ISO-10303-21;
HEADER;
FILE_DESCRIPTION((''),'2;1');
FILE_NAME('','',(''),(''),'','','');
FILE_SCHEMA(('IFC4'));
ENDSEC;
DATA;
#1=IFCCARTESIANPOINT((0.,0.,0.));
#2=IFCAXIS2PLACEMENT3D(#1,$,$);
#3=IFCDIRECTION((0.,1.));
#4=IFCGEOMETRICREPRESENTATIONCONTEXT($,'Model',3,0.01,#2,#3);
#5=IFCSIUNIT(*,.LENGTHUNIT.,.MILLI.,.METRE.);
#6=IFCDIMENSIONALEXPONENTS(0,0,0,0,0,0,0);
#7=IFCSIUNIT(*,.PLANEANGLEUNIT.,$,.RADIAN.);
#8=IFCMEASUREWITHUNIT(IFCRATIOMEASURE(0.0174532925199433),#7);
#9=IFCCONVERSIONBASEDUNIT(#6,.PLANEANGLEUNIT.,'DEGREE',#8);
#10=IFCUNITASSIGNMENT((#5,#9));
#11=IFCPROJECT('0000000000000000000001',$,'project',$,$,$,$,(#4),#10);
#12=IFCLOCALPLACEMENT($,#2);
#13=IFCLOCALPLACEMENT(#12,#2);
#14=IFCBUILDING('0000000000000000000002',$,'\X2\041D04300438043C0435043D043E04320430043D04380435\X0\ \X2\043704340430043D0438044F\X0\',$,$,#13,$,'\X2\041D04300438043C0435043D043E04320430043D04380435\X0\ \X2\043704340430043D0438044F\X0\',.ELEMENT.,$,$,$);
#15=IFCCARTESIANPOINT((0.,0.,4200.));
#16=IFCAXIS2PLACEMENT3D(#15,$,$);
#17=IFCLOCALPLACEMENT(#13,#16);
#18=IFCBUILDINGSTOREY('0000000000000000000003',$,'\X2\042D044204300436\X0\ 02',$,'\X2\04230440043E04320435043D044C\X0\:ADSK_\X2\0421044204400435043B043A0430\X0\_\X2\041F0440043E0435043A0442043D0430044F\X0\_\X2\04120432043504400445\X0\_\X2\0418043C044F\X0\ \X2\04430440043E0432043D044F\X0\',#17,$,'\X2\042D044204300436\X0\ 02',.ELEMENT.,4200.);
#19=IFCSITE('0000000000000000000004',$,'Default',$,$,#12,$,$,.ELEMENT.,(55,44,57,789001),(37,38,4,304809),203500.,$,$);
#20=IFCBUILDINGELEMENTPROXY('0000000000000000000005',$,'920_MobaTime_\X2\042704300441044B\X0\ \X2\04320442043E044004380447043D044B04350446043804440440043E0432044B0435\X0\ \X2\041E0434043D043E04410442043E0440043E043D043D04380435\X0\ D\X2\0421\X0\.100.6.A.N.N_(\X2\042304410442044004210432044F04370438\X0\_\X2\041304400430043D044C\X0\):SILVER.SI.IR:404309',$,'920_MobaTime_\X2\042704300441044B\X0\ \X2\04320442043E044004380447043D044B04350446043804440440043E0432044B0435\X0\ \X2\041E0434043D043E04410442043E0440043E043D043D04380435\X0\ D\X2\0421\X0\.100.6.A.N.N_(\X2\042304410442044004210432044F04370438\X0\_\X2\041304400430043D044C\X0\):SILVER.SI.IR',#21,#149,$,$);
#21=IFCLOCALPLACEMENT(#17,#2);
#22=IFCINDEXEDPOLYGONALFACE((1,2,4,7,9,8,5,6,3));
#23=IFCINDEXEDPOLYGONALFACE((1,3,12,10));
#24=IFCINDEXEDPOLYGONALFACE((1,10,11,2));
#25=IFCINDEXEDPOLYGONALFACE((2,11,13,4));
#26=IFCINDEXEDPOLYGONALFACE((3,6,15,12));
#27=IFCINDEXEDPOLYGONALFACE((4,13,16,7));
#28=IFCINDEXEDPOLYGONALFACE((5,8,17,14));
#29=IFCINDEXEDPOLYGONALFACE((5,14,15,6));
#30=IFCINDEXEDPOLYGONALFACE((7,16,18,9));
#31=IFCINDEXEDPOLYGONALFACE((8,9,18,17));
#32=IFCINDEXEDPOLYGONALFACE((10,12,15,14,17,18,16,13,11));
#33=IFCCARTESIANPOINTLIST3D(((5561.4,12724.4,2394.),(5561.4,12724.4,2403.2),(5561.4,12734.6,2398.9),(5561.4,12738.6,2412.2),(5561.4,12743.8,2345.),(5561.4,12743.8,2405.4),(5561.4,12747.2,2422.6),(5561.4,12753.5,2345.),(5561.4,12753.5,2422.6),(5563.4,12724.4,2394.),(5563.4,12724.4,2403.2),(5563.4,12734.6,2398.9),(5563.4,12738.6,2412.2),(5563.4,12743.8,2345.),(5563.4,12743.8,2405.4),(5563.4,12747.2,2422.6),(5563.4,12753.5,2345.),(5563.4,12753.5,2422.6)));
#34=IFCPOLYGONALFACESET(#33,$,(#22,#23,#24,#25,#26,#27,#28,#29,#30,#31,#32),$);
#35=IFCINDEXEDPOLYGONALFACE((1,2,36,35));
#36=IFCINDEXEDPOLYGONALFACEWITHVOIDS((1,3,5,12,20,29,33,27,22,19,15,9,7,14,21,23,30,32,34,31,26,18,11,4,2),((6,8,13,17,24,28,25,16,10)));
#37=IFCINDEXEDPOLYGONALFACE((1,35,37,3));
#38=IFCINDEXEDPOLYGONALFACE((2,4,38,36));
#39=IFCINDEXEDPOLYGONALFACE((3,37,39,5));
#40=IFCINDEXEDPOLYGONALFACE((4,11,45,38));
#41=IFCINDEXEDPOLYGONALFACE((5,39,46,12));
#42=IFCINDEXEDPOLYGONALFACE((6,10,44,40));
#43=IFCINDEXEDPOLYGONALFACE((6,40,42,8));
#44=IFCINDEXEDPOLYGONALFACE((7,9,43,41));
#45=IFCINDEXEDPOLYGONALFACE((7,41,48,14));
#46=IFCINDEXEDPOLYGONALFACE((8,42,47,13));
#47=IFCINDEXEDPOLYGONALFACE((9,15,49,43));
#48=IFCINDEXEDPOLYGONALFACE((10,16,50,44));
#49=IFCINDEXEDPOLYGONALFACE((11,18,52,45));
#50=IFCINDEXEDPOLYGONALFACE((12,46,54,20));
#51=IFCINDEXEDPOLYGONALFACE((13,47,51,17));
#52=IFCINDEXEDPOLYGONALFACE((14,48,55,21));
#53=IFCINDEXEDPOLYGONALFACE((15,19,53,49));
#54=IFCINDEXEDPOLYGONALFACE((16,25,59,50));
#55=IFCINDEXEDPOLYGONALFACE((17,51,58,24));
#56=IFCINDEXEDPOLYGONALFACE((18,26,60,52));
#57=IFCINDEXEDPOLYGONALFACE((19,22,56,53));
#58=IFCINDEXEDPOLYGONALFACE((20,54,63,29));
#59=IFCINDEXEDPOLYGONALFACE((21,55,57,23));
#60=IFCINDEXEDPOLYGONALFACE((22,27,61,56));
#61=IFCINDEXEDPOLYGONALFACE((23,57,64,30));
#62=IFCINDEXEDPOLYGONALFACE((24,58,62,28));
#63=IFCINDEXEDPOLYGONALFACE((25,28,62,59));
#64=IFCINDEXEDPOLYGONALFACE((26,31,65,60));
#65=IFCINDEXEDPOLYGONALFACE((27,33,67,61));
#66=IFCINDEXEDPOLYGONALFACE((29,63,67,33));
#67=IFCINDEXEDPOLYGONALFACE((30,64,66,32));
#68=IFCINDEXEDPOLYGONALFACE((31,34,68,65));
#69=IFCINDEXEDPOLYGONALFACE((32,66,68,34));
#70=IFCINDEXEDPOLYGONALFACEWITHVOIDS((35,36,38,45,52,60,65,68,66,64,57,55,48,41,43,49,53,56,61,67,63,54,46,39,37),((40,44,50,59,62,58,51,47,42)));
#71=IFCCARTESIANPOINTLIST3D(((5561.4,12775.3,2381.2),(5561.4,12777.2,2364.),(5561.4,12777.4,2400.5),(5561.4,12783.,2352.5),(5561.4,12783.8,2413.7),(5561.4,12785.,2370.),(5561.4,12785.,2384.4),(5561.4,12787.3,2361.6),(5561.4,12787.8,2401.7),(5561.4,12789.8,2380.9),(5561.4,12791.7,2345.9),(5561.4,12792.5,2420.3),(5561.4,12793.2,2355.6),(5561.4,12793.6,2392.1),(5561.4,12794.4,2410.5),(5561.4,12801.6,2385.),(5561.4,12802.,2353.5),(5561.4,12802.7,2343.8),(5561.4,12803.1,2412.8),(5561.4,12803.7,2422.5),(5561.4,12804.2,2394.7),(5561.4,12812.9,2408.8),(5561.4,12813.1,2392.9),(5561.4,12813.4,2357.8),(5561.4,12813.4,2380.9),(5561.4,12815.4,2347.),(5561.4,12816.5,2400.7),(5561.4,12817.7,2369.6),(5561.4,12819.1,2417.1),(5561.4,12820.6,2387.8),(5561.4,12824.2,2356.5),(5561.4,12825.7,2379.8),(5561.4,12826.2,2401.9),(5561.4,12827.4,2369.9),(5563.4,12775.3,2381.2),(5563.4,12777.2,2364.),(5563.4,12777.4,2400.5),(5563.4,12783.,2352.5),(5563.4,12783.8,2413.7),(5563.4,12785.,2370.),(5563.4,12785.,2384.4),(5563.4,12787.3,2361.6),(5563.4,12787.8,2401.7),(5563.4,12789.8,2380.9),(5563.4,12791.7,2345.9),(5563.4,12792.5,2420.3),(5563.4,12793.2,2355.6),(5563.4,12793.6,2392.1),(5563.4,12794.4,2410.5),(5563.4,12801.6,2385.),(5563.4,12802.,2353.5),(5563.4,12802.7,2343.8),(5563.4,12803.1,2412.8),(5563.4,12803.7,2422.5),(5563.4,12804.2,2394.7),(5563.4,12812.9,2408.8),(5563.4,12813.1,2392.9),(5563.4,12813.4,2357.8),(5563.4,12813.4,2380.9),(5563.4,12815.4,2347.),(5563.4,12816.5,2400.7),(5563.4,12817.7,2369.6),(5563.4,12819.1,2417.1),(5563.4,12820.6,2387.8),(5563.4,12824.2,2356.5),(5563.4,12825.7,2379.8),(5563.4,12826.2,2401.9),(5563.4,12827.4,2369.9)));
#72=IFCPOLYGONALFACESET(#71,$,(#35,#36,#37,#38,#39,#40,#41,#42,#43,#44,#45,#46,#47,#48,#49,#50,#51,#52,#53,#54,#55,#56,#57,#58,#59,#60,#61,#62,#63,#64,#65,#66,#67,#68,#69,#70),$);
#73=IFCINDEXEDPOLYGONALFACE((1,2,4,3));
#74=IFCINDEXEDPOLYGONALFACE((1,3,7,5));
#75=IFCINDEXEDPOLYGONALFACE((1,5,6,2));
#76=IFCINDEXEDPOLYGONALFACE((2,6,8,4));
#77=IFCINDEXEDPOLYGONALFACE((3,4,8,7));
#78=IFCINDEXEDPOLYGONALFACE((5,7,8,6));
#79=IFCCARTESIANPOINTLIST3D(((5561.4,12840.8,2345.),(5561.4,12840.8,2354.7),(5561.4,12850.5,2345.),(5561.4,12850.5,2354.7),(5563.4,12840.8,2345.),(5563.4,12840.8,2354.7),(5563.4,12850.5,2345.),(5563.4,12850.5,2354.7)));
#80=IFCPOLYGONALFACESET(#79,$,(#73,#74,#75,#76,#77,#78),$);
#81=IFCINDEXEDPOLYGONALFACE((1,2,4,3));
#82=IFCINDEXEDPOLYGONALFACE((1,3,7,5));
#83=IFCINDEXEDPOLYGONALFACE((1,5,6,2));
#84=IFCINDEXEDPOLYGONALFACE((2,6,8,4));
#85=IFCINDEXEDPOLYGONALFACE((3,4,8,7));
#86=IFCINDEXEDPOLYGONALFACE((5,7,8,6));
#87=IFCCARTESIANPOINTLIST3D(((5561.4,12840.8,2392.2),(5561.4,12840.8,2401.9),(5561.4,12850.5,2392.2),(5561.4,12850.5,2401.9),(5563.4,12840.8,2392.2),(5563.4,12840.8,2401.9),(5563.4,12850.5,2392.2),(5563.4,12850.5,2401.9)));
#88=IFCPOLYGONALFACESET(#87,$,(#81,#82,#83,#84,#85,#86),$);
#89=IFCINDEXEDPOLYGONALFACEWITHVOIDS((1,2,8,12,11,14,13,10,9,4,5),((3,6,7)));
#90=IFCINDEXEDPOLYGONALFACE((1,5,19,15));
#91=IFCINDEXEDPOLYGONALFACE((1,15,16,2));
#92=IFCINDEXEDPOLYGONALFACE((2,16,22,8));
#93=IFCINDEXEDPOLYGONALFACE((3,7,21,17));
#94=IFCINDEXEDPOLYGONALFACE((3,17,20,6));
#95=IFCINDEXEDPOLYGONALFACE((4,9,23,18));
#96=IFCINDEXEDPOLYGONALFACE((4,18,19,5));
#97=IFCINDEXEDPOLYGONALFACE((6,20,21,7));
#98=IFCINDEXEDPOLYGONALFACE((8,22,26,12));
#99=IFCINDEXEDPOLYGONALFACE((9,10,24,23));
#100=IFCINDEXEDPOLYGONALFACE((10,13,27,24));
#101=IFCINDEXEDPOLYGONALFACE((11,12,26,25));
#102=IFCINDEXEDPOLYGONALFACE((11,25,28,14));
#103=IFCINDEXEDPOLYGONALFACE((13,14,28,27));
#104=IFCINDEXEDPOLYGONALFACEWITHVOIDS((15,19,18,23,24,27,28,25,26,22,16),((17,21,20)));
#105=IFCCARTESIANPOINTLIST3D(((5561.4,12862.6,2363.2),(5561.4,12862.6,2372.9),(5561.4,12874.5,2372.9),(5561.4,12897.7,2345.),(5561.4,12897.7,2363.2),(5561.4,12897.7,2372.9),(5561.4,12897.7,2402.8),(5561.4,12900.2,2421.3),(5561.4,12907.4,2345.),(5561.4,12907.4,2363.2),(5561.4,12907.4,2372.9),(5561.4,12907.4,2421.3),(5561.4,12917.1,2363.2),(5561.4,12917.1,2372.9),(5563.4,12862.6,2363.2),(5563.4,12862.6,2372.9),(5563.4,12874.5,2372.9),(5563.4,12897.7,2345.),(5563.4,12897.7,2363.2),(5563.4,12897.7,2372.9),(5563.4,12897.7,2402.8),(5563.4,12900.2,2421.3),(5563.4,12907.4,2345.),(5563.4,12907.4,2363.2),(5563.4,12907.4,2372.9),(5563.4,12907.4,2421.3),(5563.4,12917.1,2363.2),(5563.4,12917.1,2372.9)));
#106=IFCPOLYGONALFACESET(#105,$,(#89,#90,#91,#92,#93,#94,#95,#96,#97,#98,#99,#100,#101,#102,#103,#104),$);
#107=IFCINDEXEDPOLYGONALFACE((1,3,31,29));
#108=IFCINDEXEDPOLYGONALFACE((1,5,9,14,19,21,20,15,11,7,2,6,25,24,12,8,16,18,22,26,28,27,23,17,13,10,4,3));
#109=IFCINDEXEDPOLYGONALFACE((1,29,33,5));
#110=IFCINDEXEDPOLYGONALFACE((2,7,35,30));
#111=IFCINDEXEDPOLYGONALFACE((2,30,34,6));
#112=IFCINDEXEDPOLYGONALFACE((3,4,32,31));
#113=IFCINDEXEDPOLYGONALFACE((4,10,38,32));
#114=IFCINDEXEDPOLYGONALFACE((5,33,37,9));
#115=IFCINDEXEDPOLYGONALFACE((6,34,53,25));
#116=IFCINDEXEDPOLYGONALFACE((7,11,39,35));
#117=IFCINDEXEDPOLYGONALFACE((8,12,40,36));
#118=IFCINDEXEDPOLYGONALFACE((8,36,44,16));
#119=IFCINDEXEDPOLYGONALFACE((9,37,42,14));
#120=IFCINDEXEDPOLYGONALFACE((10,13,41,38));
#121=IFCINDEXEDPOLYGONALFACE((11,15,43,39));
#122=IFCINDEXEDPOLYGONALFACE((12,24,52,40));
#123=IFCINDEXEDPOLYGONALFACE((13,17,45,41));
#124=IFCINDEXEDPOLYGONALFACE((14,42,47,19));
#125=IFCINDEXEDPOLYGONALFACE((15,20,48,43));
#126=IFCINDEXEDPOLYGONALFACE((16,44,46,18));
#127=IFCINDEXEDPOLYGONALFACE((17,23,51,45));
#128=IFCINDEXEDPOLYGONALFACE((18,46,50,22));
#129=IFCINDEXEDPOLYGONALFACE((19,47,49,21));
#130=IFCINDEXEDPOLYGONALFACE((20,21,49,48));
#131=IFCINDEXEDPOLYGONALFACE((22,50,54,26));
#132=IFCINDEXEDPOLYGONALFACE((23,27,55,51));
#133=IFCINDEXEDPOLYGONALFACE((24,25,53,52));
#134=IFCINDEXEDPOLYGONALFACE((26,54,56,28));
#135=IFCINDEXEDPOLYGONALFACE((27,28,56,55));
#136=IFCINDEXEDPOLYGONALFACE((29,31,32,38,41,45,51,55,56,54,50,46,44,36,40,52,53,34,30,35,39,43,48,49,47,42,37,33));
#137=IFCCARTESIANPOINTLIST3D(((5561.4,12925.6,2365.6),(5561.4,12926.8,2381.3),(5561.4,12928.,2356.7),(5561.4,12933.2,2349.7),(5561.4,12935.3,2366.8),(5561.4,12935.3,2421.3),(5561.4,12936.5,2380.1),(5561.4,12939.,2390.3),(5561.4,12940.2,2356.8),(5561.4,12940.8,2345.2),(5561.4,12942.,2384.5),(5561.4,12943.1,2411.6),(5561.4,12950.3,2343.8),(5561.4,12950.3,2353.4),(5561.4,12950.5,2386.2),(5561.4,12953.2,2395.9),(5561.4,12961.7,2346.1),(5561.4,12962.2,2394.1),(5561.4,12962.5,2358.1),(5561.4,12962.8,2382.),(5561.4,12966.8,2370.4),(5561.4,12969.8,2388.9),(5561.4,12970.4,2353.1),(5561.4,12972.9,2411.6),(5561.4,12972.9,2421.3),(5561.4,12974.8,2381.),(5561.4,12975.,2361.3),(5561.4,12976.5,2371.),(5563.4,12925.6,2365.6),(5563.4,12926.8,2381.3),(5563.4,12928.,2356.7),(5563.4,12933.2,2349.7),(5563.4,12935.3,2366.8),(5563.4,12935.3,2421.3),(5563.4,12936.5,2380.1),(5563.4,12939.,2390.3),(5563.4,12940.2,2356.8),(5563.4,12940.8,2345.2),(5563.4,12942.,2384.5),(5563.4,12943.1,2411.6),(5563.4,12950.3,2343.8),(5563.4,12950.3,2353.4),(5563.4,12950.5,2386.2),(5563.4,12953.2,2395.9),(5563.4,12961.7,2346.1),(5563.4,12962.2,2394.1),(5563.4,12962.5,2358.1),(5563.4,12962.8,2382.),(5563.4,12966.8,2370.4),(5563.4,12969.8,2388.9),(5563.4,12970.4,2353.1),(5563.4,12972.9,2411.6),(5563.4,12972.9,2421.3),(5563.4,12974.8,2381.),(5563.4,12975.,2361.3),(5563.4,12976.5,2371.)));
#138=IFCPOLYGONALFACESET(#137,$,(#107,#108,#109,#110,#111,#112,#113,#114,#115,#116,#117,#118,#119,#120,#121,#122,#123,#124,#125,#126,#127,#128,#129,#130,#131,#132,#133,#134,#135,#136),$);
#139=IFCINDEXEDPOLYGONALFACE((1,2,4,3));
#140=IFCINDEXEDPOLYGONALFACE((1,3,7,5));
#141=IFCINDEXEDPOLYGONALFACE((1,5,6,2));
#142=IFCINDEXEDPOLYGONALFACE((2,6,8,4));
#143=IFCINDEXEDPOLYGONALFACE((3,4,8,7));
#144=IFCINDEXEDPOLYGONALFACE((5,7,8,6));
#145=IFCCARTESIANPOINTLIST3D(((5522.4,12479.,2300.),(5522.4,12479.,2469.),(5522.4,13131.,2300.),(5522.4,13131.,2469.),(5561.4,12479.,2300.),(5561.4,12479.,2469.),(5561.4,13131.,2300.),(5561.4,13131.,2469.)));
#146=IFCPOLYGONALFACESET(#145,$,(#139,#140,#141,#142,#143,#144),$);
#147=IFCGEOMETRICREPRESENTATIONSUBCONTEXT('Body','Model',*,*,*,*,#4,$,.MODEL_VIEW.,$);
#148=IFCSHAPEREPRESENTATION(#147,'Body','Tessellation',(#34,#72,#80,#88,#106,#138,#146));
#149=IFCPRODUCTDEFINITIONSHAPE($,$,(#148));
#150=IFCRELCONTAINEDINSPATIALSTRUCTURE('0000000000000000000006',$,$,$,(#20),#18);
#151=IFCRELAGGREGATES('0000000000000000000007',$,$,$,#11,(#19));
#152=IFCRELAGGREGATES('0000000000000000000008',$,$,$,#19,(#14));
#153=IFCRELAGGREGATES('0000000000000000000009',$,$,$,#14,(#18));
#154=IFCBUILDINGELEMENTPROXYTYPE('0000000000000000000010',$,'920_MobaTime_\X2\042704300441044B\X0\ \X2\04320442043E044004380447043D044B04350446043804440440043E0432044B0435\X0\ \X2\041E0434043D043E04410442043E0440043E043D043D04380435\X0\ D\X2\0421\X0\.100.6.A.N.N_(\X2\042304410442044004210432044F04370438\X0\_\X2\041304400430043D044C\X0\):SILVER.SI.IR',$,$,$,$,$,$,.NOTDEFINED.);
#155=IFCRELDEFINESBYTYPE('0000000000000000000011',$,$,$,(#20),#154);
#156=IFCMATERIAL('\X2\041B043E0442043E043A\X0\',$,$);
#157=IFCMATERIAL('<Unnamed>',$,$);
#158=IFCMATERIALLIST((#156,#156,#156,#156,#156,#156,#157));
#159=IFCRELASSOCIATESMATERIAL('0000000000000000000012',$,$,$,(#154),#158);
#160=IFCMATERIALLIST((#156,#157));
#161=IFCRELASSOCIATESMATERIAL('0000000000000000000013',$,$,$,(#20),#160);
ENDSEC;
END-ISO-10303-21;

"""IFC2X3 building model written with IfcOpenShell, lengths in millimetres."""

from ifc_helpers import new_model, entity, si_unit, converted_unit, direction, frame, origin, origin_2d_with_axis, place, context, subcontext, project, spatial, polyline, rectangle, outline, extrude, source, transform, mapped, material, material_list, type_object, type_shapes, element, save


model = new_model("IFC2X3")

# Units and contexts
model_context = context("Model", 3, precision=0.01, world=origin(), true_north=direction((0.0, 1.0)))
body_context = subcontext(model_context, "Body", "Model", "MODEL_VIEW")
ifc_project = project(units=[si_unit("LENGTHUNIT", "METRE", prefix="MILLI"), converted_unit("PLANEANGLEUNIT", "DEGREE", entity("IfcRatioMeasure", 0.0174532925199433), si_unit("PLANEANGLEUNIT", "RADIAN"), dimensions=[0, 0, 0, 0, 0, 0, 0])], contexts=[model_context])

# Site, building, storey
site_placement = place(None, origin())
site = spatial("IfcSite", under=ifc_project, at=site_placement, Name="Default", CompositionType="ELEMENT", RefLatitude=(55, 44, 57, 789001), RefLongitude=(37, 38, 4, 304809), RefElevation=203500.0)
building_placement = place(site_placement, origin())
building = spatial("IfcBuilding", under=site, at=building_placement, Name="Наименование здания", LongName="Наименование здания", CompositionType="ELEMENT")
storey_placement = place(building_placement, frame((0.0, 0.0, 4200.0)))
storey = spatial("IfcBuildingStorey", under=building, at=storey_placement, Name="Этаж 02", ObjectType="Уровень:ADSK_Стрелка_Проектная_Вверх_Имя уровня", LongName="Этаж 02", CompositionType="ELEMENT", Elevation=4200.0)

# Building element proxy
ifc_material_1 = material(Name="Лоток")
ifc_material_2 = material(Name="<Unnamed>")
ifc_material_list_1 = material_list([ifc_material_1, ifc_material_2])
ifc_material_list_2 = material_list([ifc_material_1, ifc_material_1, ifc_material_1, ifc_material_1, ifc_material_1, ifc_material_1, ifc_material_2])
building_element_proxy_type_1 = type_object("IfcBuildingElementProxyType", Name="920_MobaTime_Часы вторичныецифровые Односторонние DС.100.6.A.N.N_(УстрСвязи_Грань):SILVER.SI.IR", PredefinedType="NOTDEFINED", material=ifc_material_list_2)
shared_shape_1 = source(origin(), body_context, "Body", "SweptSolid", [
    extrude(outline(polyline([(-49.3, -13.1), (28.2, -13.1), (28.2, -6.8), (17.9, 1.8), (8.8, 16.0), (-0.3, 16.0), (4.6, 5.8), (11.1, -3.4), (-49.3, -3.4), (-49.3, -13.1)])), frame((-64.6, 9.8, 39.0), z_axis=(0.0, 0.0, 1.0), x_axis=(0.0, 1.0, 0.0)), (0.0, 0.0, 1.0), 2.0),
    extrude(outline(polyline([(2.2, -27.6), (19.0, -27.6), (30.5, -16.1), (33.3, -4.9), (31.0, 5.8), (21.8, 17.2), (5.2, 27.3), (-11.1, 33.0), (-24.0, 32.7), (-33.6, 27.6), (-40.3, 18.6), (-42.8, 5.7), (-38.0, -6.3), (-27.2, -14.9), (-17.5, -17.7), (-8.2, -16.4), (-0.3, -11.9), (5.1, -4.5), (7.3, 6.2), (4.0, 17.2), (18.4, 7.3), (23.6, -2.4), (22.0, -11.4), (14.2, -18.4), (5.3, -18.3), (2.2, -27.6)]), holes=[polyline([(-9.0, 23.3), (-1.3, 14.3), (-2.5, 2.0), (-11.4, -7.0), (-23.4, -6.0), (-32.2, 2.9), (-31.2, 15.1), (-25.6, 22.1), (-17.5, 24.9), (-9.0, 23.3)])]), frame((-2.7, 3.6, 39.0), z_axis=(0.0, 0.0, 1.0), x_axis=(-0.427649, 0.903945, 0.0)), (0.0, 0.0, 1.0), 2.0),
    extrude(rectangle(XDim=9.7, YDim=9.7, at=origin_2d_with_axis()), frame((40.6, -34.7, 39.0)), (0.0, 0.0, 1.0), 2.0),
    extrude(rectangle(XDim=9.7, YDim=9.7, at=origin_2d_with_axis()), frame((40.6, 12.6, 39.0)), (0.0, 0.0, 1.0), 2.0),
    extrude(outline(polyline([(-0.9, -28.1), (8.8, -28.1), (8.8, -9.9), (18.5, -9.9), (18.5, -0.2), (8.8, -0.2), (8.8, 48.3), (1.5, 48.3), (-36.0, -0.2), (-36.0, -9.9), (-0.9, -9.9), (-0.9, -28.1)]), holes=[polyline([(-0.9, -0.2), (-24.1, -0.2), (-0.9, 29.7), (-0.9, -0.2)])]), frame((93.6, -11.4, 39.0)), (0.0, 0.0, 1.0), 2.0),
    extrude(outline(polyline([(3.3, -28.3), (12.5, -28.3), (20.5, -25.0), (26.8, -18.9), (30.7, -10.0), (31.4, 1.6), (26.9, 11.8), (20.1, 18.4), (11.1, 22.3), (1.0, 23.3), (-7.9, 20.4), (-14.9, 14.5), (-18.9, 6.2), (-17.1, -9.0), (-36.7, 0.5), (-29.1, 29.2), (-38.5, 31.7), (-48.1, -4.6), (-11.6, -23.1), (-8.0, -14.0), (-10.8, -7.6), (-10.2, 1.1), (-3.0, 11.8), (9.2, 12.8), (20.0, 5.5), (21.4, -7.5), (15.5, -16.4), (4.6, -18.6), (3.3, -28.3)])), frame((147.1, -8.5, 39.0), z_axis=(0.0, 0.0, 1.0), x_axis=(0.256974, -0.966418, 0.0)), (0.0, 0.0, 1.0), 2.0),
    extrude(rectangle(XDim=652.0, YDim=169.0, at=origin_2d_with_axis()), frame((0.0, 0.0, 0.0), z_axis=(0.0, 0.0, 1.0), x_axis=(-1.0, 0.0, 0.0)), (0.0, 0.0, 1.0), 39.0),
])
type_shapes(building_element_proxy_type_1, [shared_shape_1])
for number, where, z_axis, x_axis, name in (
    (1, (5522.4, 12805.0, 2384.5), (1.0, 0.0, 0.0), (0.0, 1.0, 0.0), "920_MobaTime_Часы вторичныецифровые Односторонние DС.100.6.A.N.N_(УстрСвязи_Грань):SILVER.SI.IR:404309"),
):
    element("IfcBuildingElementProxy", number, at=place(storey_placement, frame(where, z_axis=z_axis, x_axis=x_axis)), inside=storey, type_object=building_element_proxy_type_1, material=ifc_material_list_1, Name=name, ObjectType="920_MobaTime_Часы вторичныецифровые Односторонние DС.100.6.A.N.N_(УстрСвязи_Грань):SILVER.SI.IR", context=body_context, shape_type="MappedRepresentation", body=[
        mapped(shared_shape_1, transform((0.0, 0.0, 0.0), scale=1.0)),
    ])

save(model, "model.ifc")
